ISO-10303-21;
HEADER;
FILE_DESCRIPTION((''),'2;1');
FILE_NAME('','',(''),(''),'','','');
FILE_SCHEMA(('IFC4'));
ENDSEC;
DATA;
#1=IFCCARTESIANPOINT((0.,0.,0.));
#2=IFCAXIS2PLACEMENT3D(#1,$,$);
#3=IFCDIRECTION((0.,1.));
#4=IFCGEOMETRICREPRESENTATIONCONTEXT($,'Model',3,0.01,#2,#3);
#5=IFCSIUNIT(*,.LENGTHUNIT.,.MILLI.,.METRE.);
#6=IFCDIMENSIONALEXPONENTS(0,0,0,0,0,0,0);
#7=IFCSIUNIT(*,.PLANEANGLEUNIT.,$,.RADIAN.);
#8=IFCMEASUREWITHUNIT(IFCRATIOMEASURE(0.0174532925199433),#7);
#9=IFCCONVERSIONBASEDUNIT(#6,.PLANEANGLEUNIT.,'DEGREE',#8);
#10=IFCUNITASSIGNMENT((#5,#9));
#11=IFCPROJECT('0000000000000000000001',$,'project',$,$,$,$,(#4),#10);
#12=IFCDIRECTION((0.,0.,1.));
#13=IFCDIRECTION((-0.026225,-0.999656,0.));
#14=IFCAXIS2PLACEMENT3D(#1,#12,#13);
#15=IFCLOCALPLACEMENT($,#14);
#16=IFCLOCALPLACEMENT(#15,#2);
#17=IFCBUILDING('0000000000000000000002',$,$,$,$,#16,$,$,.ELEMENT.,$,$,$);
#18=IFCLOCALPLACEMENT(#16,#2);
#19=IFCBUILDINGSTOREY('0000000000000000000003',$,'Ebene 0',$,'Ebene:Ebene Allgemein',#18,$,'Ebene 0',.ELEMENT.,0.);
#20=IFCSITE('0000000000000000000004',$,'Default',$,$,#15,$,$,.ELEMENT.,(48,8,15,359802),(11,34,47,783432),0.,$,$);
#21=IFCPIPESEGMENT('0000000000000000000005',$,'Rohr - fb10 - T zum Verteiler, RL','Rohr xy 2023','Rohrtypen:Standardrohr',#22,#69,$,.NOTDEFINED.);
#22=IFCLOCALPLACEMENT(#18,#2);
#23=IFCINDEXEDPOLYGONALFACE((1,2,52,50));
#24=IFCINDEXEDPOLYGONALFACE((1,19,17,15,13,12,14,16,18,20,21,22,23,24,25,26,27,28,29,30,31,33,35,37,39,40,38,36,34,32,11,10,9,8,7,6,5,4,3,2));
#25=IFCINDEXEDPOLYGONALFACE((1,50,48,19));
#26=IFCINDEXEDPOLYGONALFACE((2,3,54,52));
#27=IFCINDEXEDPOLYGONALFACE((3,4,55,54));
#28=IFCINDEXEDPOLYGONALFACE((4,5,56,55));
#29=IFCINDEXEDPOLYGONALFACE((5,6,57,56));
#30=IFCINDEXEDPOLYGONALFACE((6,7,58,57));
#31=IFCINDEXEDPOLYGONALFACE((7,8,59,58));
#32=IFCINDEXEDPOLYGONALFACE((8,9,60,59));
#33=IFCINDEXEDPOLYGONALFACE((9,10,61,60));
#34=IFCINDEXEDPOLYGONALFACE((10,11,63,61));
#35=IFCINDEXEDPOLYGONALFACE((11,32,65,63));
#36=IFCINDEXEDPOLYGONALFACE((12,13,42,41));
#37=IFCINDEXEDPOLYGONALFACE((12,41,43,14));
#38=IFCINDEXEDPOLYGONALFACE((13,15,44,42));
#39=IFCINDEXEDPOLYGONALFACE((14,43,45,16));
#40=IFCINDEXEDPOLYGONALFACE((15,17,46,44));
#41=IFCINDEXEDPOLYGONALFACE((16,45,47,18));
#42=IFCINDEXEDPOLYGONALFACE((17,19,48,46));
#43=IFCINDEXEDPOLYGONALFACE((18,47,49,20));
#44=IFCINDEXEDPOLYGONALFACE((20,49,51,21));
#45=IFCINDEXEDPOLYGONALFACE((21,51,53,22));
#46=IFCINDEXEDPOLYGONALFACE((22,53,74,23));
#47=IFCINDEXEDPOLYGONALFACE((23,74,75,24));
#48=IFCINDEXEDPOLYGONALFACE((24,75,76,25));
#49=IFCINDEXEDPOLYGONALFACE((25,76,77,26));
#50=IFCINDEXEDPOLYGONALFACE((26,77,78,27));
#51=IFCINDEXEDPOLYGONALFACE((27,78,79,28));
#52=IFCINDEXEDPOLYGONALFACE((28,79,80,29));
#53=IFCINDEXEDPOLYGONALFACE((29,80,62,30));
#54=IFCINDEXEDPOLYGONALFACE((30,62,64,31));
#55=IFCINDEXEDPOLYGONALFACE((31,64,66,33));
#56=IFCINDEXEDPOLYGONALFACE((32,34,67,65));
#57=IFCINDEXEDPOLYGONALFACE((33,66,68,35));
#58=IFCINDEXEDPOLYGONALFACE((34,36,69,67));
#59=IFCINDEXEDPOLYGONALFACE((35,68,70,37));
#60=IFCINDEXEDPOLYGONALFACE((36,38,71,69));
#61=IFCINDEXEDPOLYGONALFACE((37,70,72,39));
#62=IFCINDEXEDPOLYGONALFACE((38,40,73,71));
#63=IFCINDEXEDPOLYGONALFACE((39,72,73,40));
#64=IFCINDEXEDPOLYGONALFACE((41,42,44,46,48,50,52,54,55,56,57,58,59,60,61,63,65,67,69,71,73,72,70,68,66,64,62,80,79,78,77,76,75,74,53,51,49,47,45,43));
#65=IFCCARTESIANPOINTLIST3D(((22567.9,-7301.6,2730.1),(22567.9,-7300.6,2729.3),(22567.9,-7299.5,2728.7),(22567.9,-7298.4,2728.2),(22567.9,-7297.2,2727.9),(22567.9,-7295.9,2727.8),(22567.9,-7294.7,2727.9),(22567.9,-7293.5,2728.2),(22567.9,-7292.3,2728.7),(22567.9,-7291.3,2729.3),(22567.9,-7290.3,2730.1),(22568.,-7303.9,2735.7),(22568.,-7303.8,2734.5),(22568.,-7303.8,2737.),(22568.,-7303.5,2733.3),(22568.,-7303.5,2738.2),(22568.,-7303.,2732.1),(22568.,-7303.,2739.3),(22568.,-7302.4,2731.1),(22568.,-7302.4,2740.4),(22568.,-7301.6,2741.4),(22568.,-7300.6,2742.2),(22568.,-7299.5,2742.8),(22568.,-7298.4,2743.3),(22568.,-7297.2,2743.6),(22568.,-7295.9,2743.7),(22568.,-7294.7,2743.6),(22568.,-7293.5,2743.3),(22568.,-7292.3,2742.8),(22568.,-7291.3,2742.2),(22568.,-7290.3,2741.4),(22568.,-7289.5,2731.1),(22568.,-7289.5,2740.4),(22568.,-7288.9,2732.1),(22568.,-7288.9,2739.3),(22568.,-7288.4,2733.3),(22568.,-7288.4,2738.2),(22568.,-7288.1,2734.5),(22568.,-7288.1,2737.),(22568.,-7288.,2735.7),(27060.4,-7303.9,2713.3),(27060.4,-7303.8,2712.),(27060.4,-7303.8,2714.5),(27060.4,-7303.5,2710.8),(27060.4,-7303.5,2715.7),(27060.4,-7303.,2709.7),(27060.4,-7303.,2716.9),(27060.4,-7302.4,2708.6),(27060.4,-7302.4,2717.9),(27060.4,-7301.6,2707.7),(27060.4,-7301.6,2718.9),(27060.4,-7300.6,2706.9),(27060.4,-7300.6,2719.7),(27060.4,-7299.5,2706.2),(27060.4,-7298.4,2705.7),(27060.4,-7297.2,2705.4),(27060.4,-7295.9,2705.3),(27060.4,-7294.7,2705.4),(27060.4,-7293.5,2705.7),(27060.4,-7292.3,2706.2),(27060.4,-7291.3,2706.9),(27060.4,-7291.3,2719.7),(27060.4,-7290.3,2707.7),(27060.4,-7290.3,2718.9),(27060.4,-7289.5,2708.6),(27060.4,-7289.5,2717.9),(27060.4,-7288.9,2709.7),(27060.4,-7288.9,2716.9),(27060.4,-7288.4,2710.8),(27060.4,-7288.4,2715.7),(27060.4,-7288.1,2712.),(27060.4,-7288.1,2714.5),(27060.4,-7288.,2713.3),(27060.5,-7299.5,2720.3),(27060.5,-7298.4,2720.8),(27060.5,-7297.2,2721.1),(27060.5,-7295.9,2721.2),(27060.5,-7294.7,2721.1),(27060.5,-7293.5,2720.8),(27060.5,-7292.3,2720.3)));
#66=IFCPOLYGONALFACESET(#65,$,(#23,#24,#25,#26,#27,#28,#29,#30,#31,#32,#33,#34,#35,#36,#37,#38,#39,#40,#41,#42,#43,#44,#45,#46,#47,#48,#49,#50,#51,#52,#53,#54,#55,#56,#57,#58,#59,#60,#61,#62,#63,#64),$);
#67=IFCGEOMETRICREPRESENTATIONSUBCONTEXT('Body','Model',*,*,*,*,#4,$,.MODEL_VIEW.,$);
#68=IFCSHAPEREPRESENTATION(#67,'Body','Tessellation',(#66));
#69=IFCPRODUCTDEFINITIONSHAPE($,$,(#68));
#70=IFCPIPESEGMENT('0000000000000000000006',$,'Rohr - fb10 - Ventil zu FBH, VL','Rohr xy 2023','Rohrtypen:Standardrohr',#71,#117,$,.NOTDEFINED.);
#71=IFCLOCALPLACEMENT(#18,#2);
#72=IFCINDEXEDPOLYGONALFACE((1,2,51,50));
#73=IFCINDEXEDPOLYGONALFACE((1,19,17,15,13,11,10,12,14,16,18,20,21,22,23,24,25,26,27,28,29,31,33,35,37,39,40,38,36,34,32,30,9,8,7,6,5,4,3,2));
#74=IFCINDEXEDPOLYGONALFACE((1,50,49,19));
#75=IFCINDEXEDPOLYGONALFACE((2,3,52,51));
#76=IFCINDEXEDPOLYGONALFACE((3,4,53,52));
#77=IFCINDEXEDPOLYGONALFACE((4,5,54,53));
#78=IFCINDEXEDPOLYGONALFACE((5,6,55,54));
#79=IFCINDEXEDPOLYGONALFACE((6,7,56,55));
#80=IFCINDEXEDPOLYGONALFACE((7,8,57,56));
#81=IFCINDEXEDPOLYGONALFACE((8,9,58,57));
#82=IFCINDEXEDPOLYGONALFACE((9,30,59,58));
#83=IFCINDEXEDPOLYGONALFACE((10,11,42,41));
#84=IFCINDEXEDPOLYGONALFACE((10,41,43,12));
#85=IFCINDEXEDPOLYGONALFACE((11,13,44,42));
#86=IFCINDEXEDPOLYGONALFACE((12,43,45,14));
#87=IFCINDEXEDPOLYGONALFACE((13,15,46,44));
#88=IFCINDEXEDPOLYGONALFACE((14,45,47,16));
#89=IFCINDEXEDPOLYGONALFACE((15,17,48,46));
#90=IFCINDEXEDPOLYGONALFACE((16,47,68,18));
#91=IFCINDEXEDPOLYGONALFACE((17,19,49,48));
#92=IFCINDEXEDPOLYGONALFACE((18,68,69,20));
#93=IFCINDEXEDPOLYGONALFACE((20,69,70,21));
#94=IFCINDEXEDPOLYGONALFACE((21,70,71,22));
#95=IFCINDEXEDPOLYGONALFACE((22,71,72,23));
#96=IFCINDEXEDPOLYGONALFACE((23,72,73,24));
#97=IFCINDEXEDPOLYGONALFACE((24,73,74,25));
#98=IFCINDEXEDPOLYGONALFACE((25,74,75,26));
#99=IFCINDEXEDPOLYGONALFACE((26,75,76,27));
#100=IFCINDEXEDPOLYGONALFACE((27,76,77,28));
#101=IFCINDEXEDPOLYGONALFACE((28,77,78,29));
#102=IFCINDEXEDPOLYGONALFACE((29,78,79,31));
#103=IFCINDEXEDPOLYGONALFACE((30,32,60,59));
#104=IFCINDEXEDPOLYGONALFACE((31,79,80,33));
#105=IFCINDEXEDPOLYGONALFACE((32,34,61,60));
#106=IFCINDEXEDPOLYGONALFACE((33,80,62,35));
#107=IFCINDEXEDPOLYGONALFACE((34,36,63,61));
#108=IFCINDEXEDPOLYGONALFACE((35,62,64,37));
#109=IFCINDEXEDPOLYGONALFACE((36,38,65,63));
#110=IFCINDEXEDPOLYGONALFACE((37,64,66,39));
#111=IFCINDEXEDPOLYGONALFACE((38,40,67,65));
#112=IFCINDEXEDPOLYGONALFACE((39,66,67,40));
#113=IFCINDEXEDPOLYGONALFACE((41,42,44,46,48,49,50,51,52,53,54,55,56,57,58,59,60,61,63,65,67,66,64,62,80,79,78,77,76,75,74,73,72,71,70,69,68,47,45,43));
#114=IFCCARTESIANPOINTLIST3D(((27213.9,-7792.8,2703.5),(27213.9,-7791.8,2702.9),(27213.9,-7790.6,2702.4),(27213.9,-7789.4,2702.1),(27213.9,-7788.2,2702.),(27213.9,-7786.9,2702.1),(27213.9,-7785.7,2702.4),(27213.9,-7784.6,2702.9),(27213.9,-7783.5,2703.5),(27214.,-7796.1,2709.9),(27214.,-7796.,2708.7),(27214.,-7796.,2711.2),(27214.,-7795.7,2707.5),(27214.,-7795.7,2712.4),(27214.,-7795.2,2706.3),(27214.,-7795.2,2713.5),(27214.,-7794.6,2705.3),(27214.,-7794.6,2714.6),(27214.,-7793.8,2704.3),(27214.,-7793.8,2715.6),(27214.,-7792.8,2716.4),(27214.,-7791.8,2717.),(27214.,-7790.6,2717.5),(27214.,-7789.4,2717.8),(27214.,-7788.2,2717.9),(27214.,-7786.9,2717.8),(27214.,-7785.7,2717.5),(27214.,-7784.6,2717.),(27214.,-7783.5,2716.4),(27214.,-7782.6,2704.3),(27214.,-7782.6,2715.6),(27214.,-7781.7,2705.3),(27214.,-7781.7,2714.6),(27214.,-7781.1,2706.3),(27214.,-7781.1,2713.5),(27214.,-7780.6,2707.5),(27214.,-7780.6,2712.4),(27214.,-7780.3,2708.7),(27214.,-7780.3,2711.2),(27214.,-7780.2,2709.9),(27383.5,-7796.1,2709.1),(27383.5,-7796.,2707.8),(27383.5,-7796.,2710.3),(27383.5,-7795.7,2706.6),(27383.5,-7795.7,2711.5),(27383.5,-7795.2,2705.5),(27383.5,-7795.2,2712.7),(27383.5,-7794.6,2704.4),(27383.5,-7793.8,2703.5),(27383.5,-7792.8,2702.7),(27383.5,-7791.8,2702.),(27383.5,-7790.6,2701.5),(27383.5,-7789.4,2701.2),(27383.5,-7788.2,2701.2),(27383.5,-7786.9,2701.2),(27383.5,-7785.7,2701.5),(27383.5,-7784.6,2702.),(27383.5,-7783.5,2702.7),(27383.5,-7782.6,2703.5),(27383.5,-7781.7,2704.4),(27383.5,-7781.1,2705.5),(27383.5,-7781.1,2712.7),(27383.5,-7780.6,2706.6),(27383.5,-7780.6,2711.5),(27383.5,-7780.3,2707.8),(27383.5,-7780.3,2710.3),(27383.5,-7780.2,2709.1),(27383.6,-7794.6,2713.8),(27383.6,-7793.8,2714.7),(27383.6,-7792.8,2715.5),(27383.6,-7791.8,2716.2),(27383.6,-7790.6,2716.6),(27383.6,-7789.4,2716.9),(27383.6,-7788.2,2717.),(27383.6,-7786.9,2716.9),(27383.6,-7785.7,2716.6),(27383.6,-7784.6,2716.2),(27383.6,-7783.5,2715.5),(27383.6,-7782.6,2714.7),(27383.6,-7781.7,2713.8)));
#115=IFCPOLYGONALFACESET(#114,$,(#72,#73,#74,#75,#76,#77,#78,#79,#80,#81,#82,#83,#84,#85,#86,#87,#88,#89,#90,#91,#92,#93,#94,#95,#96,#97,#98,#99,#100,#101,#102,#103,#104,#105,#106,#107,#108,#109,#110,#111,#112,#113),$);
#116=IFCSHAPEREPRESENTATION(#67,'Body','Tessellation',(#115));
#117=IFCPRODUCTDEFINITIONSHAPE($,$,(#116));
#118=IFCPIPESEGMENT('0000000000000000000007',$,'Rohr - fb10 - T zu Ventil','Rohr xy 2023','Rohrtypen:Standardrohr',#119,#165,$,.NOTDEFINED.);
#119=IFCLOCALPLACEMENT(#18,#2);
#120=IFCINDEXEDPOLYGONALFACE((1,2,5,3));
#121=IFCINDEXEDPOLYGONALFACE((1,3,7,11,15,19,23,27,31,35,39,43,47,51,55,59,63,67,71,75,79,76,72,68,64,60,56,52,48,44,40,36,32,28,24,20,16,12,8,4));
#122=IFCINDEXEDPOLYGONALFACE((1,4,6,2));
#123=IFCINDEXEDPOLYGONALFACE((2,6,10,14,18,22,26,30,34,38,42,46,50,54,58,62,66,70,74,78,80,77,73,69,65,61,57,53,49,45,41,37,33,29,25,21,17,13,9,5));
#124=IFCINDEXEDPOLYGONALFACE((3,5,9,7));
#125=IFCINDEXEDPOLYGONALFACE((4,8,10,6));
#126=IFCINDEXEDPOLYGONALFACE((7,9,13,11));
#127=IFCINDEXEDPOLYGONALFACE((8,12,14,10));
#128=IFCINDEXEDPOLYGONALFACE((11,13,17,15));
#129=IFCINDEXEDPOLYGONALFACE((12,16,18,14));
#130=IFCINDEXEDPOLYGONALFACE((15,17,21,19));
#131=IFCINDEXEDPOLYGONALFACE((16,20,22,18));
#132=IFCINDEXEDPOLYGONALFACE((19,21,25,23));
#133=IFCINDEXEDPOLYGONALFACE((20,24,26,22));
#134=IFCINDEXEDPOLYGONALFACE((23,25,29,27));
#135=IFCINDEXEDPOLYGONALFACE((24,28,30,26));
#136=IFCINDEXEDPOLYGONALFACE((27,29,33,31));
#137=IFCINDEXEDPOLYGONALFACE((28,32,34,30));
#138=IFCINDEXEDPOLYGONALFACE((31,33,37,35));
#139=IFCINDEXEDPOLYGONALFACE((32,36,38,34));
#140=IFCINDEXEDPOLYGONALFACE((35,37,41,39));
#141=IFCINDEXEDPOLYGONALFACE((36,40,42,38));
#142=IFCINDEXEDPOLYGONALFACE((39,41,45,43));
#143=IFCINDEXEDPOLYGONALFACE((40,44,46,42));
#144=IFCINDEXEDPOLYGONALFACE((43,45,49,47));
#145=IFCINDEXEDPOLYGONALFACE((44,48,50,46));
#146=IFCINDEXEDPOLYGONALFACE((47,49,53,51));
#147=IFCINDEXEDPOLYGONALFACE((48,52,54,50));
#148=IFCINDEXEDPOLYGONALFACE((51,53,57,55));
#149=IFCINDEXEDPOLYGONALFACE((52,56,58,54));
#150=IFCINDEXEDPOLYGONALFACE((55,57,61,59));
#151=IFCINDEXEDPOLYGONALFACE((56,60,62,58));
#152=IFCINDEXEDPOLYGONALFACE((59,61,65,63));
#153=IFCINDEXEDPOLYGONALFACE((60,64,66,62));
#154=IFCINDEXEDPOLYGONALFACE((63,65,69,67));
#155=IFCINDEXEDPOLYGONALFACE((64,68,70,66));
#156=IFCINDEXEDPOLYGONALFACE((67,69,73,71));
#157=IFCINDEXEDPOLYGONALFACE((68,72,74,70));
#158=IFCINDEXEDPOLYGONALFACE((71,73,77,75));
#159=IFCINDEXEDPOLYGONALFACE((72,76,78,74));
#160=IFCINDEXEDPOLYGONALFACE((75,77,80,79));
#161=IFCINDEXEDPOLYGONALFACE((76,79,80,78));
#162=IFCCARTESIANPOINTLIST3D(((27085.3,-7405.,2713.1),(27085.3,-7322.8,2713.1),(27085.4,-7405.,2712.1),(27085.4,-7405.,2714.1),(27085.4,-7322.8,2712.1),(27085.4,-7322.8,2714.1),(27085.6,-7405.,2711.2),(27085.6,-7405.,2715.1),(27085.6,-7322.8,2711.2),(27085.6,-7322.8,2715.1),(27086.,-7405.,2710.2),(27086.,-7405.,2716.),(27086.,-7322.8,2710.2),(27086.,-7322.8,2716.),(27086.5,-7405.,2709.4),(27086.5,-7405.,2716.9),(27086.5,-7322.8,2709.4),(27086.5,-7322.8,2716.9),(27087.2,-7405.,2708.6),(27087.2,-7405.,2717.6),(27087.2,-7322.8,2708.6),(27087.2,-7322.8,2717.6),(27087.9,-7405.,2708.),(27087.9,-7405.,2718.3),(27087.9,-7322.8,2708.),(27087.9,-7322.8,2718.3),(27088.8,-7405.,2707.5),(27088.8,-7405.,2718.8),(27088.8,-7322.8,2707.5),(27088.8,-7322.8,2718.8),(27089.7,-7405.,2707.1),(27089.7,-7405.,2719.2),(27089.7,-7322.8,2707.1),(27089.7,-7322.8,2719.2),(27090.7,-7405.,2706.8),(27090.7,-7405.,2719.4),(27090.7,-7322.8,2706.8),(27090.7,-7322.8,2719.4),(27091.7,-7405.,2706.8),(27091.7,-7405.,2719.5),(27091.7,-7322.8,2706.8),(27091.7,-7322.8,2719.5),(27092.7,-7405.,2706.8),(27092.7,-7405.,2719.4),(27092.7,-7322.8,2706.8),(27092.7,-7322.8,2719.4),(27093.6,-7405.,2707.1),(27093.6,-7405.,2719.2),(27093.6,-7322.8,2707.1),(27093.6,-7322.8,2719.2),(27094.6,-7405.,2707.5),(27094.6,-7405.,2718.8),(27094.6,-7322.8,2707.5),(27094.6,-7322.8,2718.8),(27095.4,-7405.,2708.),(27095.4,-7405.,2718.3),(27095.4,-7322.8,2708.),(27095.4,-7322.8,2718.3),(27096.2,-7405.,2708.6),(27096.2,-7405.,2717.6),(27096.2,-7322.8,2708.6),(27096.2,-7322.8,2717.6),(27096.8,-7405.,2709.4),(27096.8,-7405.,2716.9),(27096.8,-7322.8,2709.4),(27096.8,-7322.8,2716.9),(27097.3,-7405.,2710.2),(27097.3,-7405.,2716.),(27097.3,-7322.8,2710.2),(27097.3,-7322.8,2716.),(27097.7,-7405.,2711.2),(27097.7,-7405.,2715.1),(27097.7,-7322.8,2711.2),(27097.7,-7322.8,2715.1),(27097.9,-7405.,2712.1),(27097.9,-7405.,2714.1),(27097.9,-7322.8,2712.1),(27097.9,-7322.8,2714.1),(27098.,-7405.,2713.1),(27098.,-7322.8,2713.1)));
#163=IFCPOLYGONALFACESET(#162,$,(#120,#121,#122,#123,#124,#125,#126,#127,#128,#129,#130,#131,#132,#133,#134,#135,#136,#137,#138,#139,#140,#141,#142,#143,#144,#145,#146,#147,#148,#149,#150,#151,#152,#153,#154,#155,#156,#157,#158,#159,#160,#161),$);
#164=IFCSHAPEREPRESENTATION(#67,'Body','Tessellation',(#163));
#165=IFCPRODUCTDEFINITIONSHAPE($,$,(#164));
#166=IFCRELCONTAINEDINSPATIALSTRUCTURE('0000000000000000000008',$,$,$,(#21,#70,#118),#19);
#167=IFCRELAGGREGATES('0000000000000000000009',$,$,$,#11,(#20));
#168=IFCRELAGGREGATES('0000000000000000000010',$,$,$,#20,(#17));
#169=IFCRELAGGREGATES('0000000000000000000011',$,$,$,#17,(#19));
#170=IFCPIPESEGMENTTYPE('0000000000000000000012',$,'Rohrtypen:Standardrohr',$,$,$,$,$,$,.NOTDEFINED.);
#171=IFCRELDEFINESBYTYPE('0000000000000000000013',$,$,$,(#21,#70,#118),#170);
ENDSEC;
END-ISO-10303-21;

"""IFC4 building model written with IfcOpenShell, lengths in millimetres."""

from ifc_helpers import new_model, entity, si_unit, converted_unit, direction, frame, origin, place, context, subcontext, project, spatial, indexed_curve, outline, extrude, type_object, element, save


model = new_model("IFC4")

# Units and contexts
model_context = context("Model", 3, precision=0.01, world=origin(), true_north=direction((0.0, 1.0)))
body_context = subcontext(model_context, "Body", "Model", "MODEL_VIEW")
ifc_project = project(units=[si_unit("LENGTHUNIT", "METRE", prefix="MILLI"), converted_unit("PLANEANGLEUNIT", "DEGREE", entity("IfcRatioMeasure", 0.0174532925199433), si_unit("PLANEANGLEUNIT", "RADIAN"), dimensions=[0, 0, 0, 0, 0, 0, 0])], contexts=[model_context])

# Site, building, storey
site_placement = place(None, frame((0.0, 0.0, 0.0), z_axis=(0.0, 0.0, 1.0), x_axis=(-0.026225, -0.999656, 0.0)))
site = spatial("IfcSite", under=ifc_project, at=site_placement, Name="Default", CompositionType="ELEMENT", RefLatitude=(48, 8, 15, 359802), RefLongitude=(11, 34, 47, 783432), RefElevation=0.0)
building_placement = place(site_placement, origin())
building = spatial("IfcBuilding", under=site, at=building_placement, CompositionType="ELEMENT")
storey_placement = place(building_placement, origin())
storey = spatial("IfcBuildingStorey", under=building, at=storey_placement, Name="Ebene 0", ObjectType="Ebene:Ebene Allgemein", LongName="Ebene 0", CompositionType="ELEMENT", Elevation=0.0)

# Pipe segments
pipe_segment_type = type_object("IfcPipeSegmentType", Name="Rohrtypen:Standardrohr", PredefinedType="NOTDEFINED")
pipe_segment_1_placement = place(storey_placement, origin())
element("IfcPipeSegment", 1, at=pipe_segment_1_placement, inside=storey, type_object=pipe_segment_type, Name="Rohr - fb10 - T zum Verteiler, RL", Description="Rohr xy 2023", ObjectType="Rohrtypen:Standardrohr", PredefinedType="NOTDEFINED", context=body_context, shape_type="SweptSolid", body=[
    extrude(outline(indexed_curve([(7.9, 0.0), (7.8, 1.2), (7.6, 2.5), (7.1, 3.6), (6.4, 4.7), (5.6, 5.6), (4.7, 6.4), (3.6, 7.1), (2.5, 7.6), (1.2, 7.8), (0.0, 7.9), (-1.2, 7.8), (-2.5, 7.6), (-3.6, 7.1), (-4.7, 6.4), (-5.6, 5.6), (-6.4, 4.7), (-7.1, 3.6), (-7.6, 2.5), (-7.8, 1.2), (-7.9, 0.0), (-7.8, -1.2), (-7.6, -2.5), (-7.1, -3.6), (-6.4, -4.7), (-5.6, -5.6), (-4.7, -6.4), (-3.6, -7.1), (-2.5, -7.6), (-1.2, -7.8), (0.0, -7.9), (1.2, -7.8), (2.5, -7.6), (3.6, -7.1), (4.7, -6.4), (5.6, -5.6), (6.4, -4.7), (7.1, -3.6), (7.6, -2.5), (7.8, -1.2), (7.9, 0.0)], self_intersect=False)), frame((27060.4, -7295.9, 2713.3), z_axis=(-0.999988, 0.0, 0.005), x_axis=(0.0, 1.0, 0.0)), (0.0, 0.0, 1.0), 4492.5),
])
pipe_segment_2_placement = place(storey_placement, origin())
element("IfcPipeSegment", 2, at=pipe_segment_2_placement, inside=storey, type_object=pipe_segment_type, Name="Rohr - fb10 - Ventil zu FBH, VL", Description="Rohr xy 2023", ObjectType="Rohrtypen:Standardrohr", PredefinedType="NOTDEFINED", context=body_context, shape_type="SweptSolid", body=[
    extrude(outline(indexed_curve([(7.9, 0.0), (7.8, 1.2), (7.6, 2.5), (7.1, 3.6), (6.4, 4.7), (5.6, 5.6), (4.7, 6.4), (3.6, 7.1), (2.5, 7.6), (1.2, 7.8), (0.0, 7.9), (-1.2, 7.8), (-2.5, 7.6), (-3.6, 7.1), (-4.7, 6.4), (-5.6, 5.6), (-6.4, 4.7), (-7.1, 3.6), (-7.6, 2.5), (-7.8, 1.2), (-7.9, 0.0), (-7.8, -1.2), (-7.6, -2.5), (-7.1, -3.6), (-6.4, -4.7), (-5.6, -5.6), (-4.7, -6.4), (-3.6, -7.1), (-2.5, -7.6), (-1.2, -7.8), (0.0, -7.9), (1.2, -7.8), (2.5, -7.6), (3.6, -7.1), (4.7, -6.4), (5.6, -5.6), (6.4, -4.7), (7.1, -3.6), (7.6, -2.5), (7.8, -1.2), (7.9, 0.0)], self_intersect=False)), frame((27214.0, -7788.2, 2709.9), z_axis=(0.999988, 0.0, -0.005), x_axis=(0.0, 1.0, 0.0)), (0.0, 0.0, 1.0), 169.5),
])
pipe_segment_3_placement = place(storey_placement, origin())
element("IfcPipeSegment", 3, at=pipe_segment_3_placement, inside=storey, type_object=pipe_segment_type, Name="Rohr - fb10 - T zu Ventil", Description="Rohr xy 2023", ObjectType="Rohrtypen:Standardrohr", PredefinedType="NOTDEFINED", context=body_context, shape_type="SweptSolid", body=[
    extrude(outline(indexed_curve([(6.3, 0.0), (6.3, 1.0), (6.0, 2.0), (5.7, 2.9), (5.1, 3.7), (4.5, 4.5), (3.7, 5.1), (2.9, 5.7), (2.0, 6.0), (1.0, 6.3), (0.0, 6.4), (-1.0, 6.3), (-2.0, 6.0), (-2.9, 5.7), (-3.7, 5.1), (-4.5, 4.5), (-5.1, 3.7), (-5.7, 2.9), (-6.0, 2.0), (-6.3, 1.0), (-6.4, 0.0), (-6.3, -1.0), (-6.0, -2.0), (-5.7, -2.9), (-5.1, -3.7), (-4.5, -4.5), (-3.7, -5.1), (-2.9, -5.7), (-2.0, -6.0), (-1.0, -6.3), (0.0, -6.4), (1.0, -6.3), (2.0, -6.0), (2.9, -5.7), (3.7, -5.1), (4.5, -4.5), (5.1, -3.7), (5.7, -2.9), (6.0, -2.0), (6.3, -1.0), (6.3, 0.0)], self_intersect=False)), frame((27091.7, -7405.0, 2713.1), z_axis=(0.0, 1.0, 0.0), x_axis=(-1.0, 0.0, 0.0)), (0.0, 0.0, 1.0), 82.2),
])

save(model, "model.ifc")
